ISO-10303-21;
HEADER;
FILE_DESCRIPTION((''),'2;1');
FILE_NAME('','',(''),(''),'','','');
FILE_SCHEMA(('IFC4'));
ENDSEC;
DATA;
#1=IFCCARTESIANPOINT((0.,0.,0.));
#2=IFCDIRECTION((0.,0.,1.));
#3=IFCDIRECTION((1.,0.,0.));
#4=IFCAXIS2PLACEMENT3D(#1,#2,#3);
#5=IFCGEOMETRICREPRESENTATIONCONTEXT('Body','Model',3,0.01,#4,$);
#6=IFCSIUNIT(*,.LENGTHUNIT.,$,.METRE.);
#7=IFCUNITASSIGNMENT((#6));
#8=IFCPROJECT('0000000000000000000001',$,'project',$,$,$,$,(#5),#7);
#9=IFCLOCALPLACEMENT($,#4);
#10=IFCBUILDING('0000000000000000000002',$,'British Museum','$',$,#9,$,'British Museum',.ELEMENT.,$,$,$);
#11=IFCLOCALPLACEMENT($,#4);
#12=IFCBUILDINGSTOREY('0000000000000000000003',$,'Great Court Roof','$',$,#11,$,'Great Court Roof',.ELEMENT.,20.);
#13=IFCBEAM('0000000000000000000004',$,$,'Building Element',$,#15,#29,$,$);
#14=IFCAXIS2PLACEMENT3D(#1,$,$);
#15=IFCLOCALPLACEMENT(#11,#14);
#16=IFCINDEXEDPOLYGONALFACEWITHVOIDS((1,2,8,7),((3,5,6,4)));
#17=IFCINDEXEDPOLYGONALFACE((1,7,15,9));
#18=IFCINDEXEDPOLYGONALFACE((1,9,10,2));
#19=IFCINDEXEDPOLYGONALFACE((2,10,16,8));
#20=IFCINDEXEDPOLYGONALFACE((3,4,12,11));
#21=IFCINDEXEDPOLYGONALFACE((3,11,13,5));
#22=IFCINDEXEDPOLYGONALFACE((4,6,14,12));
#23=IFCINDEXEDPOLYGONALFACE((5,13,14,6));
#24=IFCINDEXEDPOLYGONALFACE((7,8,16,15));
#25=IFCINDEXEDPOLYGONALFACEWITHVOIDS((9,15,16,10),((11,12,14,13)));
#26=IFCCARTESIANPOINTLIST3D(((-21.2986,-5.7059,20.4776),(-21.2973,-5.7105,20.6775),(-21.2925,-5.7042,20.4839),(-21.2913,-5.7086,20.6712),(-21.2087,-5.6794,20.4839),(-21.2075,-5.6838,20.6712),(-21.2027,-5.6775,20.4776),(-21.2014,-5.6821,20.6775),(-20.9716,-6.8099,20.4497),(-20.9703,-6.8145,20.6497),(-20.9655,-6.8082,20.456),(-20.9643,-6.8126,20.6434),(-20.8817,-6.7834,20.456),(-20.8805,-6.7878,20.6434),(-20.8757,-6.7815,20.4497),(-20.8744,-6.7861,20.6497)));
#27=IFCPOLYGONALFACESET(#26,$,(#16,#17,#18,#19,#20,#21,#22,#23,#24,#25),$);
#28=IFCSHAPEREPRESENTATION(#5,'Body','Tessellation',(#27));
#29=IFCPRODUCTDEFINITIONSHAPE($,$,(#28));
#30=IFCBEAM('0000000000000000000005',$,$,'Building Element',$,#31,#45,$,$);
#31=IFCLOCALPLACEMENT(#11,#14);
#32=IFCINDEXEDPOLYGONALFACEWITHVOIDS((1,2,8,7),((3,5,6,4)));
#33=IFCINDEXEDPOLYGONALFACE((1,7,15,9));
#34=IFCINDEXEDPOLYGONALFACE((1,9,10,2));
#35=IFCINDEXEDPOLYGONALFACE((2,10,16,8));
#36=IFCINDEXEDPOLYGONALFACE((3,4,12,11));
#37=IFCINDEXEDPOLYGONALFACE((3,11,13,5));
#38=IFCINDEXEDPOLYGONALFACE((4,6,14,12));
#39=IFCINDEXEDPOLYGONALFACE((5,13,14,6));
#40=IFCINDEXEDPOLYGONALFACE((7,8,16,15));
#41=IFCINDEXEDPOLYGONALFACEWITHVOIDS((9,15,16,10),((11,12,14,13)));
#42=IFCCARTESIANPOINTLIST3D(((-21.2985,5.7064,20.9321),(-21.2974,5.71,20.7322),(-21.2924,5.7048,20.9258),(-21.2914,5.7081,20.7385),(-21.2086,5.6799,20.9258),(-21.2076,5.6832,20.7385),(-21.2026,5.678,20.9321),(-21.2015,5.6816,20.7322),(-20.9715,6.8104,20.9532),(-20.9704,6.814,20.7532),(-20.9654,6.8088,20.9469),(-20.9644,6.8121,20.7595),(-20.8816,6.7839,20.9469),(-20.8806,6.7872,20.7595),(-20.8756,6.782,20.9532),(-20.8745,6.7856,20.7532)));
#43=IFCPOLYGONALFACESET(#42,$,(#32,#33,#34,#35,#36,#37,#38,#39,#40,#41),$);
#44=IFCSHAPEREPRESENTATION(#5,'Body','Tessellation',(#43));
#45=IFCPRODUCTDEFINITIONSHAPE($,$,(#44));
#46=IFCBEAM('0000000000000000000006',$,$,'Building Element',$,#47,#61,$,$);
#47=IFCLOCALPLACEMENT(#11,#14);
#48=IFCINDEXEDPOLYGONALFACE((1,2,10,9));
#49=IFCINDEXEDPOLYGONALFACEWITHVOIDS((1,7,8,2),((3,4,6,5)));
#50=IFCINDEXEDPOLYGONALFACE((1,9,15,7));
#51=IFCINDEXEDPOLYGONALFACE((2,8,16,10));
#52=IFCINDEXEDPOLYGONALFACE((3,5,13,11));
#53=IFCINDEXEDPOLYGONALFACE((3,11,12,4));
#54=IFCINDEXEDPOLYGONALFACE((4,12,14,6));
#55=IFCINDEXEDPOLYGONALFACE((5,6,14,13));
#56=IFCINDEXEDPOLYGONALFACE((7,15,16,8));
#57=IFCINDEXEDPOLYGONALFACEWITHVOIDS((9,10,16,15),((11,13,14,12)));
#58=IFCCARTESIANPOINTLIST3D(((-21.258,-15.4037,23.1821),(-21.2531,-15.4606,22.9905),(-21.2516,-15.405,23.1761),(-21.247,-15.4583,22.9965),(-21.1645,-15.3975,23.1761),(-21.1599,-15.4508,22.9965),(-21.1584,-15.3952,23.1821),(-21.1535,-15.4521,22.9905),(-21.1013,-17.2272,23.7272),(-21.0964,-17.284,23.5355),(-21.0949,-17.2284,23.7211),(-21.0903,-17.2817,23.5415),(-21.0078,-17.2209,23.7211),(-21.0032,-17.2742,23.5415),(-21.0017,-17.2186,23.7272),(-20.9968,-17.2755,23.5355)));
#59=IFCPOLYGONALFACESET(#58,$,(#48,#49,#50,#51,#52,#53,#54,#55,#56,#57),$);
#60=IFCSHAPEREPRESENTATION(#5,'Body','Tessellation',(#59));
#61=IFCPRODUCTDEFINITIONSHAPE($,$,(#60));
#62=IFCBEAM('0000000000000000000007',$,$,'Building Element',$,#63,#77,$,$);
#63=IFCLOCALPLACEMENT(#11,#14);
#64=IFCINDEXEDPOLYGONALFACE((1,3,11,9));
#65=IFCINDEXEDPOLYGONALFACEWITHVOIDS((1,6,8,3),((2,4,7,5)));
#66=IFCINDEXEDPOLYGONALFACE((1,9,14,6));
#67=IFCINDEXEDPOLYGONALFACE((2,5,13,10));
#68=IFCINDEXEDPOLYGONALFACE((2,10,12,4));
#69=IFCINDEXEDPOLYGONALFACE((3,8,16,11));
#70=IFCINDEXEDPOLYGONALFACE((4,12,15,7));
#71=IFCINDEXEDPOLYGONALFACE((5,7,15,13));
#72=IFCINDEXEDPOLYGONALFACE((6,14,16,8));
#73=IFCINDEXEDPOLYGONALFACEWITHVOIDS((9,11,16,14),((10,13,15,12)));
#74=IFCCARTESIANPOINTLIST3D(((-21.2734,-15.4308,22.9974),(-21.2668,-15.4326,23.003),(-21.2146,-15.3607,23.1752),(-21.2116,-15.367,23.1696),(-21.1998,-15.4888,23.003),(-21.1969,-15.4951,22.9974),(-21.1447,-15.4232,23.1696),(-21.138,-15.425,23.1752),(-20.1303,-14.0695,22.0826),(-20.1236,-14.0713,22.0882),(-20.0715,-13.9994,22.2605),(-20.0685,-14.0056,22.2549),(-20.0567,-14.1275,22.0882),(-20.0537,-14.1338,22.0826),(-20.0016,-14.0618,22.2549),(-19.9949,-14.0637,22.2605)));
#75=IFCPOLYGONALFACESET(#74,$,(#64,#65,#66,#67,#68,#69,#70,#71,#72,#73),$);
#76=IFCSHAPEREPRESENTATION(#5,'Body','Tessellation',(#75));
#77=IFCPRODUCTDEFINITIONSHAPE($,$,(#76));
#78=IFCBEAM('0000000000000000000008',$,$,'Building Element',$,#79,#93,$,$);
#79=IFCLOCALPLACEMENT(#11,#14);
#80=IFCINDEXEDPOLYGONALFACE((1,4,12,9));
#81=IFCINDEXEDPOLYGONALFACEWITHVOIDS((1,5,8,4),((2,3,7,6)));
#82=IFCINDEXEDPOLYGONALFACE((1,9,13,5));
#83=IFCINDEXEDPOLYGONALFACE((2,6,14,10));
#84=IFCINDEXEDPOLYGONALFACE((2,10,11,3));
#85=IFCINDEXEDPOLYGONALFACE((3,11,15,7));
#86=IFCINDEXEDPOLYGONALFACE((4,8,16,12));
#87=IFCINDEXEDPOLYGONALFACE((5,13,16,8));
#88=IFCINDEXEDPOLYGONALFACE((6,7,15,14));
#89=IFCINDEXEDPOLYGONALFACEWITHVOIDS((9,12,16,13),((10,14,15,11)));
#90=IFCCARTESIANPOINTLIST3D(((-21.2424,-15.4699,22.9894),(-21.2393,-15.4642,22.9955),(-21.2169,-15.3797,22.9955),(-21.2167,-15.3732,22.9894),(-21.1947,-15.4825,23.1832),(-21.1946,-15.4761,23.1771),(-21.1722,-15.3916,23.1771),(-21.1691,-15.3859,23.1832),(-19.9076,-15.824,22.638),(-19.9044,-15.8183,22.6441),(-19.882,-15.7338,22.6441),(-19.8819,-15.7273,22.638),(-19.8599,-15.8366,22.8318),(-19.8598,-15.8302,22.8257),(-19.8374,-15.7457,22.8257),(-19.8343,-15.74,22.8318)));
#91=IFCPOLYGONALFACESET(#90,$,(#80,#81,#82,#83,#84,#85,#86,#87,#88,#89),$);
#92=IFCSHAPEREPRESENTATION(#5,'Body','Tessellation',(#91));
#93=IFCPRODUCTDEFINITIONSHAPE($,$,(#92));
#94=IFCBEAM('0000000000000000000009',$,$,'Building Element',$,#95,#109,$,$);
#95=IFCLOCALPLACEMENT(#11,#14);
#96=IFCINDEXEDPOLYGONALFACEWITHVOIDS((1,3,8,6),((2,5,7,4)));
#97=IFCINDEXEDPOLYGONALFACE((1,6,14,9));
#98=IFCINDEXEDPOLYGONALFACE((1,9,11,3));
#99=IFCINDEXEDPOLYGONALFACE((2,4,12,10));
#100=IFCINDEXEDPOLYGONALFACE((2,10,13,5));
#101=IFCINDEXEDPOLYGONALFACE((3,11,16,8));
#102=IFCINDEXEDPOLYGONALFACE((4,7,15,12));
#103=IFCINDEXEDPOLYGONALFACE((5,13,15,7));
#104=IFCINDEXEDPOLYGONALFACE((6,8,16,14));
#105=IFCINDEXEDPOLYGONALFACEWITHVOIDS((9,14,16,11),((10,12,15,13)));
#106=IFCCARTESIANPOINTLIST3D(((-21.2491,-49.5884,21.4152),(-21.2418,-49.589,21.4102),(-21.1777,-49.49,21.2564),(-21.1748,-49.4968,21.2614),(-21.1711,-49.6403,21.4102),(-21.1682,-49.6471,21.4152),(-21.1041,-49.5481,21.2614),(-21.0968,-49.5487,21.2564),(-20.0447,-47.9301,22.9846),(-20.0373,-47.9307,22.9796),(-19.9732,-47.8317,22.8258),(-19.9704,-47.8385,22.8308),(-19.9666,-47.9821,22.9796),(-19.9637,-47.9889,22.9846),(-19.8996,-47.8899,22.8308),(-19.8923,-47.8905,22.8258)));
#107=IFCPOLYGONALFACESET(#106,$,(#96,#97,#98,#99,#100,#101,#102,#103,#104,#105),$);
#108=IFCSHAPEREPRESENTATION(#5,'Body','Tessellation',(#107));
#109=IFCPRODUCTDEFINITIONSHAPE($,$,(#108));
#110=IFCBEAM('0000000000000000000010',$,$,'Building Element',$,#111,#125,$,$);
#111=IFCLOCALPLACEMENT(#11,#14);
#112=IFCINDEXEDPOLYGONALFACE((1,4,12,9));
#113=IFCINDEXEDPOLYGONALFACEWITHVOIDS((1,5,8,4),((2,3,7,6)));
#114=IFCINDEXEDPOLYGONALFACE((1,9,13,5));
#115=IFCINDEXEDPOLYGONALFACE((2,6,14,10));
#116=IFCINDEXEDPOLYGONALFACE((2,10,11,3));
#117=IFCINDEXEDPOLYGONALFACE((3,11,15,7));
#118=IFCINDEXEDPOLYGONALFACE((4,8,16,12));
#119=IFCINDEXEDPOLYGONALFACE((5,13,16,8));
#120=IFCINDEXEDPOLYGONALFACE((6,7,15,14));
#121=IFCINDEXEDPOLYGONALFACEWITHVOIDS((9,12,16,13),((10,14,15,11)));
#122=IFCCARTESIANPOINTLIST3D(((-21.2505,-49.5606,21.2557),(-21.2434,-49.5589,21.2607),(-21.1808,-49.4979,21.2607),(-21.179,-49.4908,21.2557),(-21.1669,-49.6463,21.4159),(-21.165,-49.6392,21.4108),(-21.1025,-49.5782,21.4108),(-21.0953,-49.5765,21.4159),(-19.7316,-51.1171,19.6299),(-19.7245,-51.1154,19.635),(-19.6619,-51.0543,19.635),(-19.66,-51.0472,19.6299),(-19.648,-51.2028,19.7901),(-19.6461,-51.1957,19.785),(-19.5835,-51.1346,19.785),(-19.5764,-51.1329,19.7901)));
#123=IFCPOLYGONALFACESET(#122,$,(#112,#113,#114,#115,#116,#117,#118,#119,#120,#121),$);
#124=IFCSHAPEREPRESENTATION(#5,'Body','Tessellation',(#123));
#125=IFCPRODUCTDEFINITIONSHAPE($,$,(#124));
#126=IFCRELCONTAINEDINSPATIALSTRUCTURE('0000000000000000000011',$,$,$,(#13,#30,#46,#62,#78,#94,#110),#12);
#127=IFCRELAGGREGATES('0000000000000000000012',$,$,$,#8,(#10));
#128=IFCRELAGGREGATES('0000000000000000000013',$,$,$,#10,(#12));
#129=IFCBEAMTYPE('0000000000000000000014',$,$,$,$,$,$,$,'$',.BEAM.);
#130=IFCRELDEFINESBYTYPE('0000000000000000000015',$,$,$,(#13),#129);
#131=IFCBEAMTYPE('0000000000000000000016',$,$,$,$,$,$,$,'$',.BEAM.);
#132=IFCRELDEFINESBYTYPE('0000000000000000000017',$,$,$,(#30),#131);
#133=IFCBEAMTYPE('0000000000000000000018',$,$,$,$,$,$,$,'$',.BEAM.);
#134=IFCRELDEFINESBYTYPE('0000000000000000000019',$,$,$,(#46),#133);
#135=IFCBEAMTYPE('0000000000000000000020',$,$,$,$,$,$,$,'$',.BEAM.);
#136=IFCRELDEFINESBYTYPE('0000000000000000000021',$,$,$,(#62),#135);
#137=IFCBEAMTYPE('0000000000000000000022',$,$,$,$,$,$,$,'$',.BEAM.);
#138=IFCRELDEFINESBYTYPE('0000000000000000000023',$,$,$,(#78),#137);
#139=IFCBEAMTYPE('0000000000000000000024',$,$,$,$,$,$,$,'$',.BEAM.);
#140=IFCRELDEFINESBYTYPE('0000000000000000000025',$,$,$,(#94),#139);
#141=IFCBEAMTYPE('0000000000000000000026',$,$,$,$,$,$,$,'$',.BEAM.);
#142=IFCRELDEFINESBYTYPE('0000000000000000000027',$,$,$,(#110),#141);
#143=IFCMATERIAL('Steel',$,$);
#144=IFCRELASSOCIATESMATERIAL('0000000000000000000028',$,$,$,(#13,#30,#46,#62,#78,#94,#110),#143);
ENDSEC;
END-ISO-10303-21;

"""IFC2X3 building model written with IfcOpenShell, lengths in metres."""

from ifc_helpers import new_model, si_unit, frame, origin_with_axes, origin_2d, place, context, project, spatial, hollow_rectangle, extrude, material, type_object, element, save


model = new_model("IFC2X3")

# Units and contexts
model_context = context("Model", 3, precision=0.01, world=origin_with_axes(), identifier="Body")
ifc_project = project(units=[si_unit("LENGTHUNIT", "METRE")], contexts=[model_context])

# Building, storey
building_placement = place(None, origin_with_axes())
building = spatial("IfcBuilding", under=ifc_project, at=building_placement, Name="British Museum", Description="$", LongName="British Museum", CompositionType="ELEMENT")
storey_placement = place(None, origin_with_axes())
storey = spatial("IfcBuildingStorey", under=building, at=storey_placement, Name="Great Court Roof", Description="$", LongName="Great Court Roof", CompositionType="ELEMENT", Elevation=20.0)

# Beams
ifc_material = material(Name="Steel")
beam_type_1 = type_object("IfcBeamType", ElementType="$", PredefinedType="BEAM")
beam_1_placement = place(None, origin_with_axes())
element("IfcBeam", 1, at=beam_1_placement, inside=storey, type_object=beam_type_1, material=ifc_material, Description="Building Element", context=model_context, shape_type="SweptSolid", body=[
    extrude(hollow_rectangle(XDim=0.1, YDim=0.2, WallThickness=0.0063, InnerFilletRadius=-0.0063, OuterFilletRadius=0.0, at=origin_2d()), frame((-21.25, -5.694, 20.5775), z_axis=(0.283917, -0.958544, -0.024167), x_axis=(0.958824, 0.284, 0.0)), (0.0, 0.0, 1.0), 1.1517),
])
beam_type_2 = type_object("IfcBeamType", ElementType="$", PredefinedType="BEAM")
beam_2_placement = place(None, origin_with_axes())
element("IfcBeam", 2, at=beam_2_placement, inside=storey, type_object=beam_type_2, material=ifc_material, Description="Building Element", context=model_context, shape_type="SweptSolid", body=[
    extrude(hollow_rectangle(XDim=0.1, YDim=0.2, WallThickness=0.0063, InnerFilletRadius=-0.0063, OuterFilletRadius=0.0, at=origin_2d()), frame((-21.25, 5.694, 20.8322), z_axis=(0.283952, 0.958664, 0.018263), x_axis=(-0.958824, 0.284, 0.0)), (0.0, 0.0, 1.0), 1.1516),
])
beam_type_3 = type_object("IfcBeamType", ElementType="$", PredefinedType="BEAM")
beam_3_placement = place(None, origin_with_axes())
element("IfcBeam", 3, at=beam_3_placement, inside=storey, type_object=beam_type_3, material=ifc_material, Description="Building Element", context=model_context, shape_type="SweptSolid", body=[
    extrude(hollow_rectangle(XDim=0.1, YDim=0.2, WallThickness=0.0063, InnerFilletRadius=-0.0063, OuterFilletRadius=0.0, at=origin_2d()), frame((-21.2057, -15.4279, 23.0863), z_axis=(0.082065, -0.954885, 0.285411), x_axis=(0.996327, 0.085626, 0.0)), (0.0, 0.0, 1.0), 1.9096),
])
beam_type_4 = type_object("IfcBeamType", ElementType="$", PredefinedType="BEAM")
beam_4_placement = place(None, origin_with_axes())
element("IfcBeam", 4, at=beam_4_placement, inside=storey, type_object=beam_type_4, material=ifc_material, Description="Building Element", context=model_context, shape_type="SweptSolid", body=[
    extrude(hollow_rectangle(XDim=0.1, YDim=0.2, WallThickness=0.0063, InnerFilletRadius=-0.0063, OuterFilletRadius=0.0, at=origin_2d()), frame((-21.2057, -15.4279, 23.0863), z_axis=(0.571802, 0.680936, -0.457568), x_axis=(-0.765807, 0.643071, 0.0)), (0.0, 0.0, 1.0), 1.9992),
])
beam_type_5 = type_object("IfcBeamType", ElementType="$", PredefinedType="BEAM")
beam_5_placement = place(None, origin_with_axes())
element("IfcBeam", 5, at=beam_5_placement, inside=storey, type_object=beam_type_5, material=ifc_material, Description="Building Element", context=model_context, shape_type="SweptSolid", body=[
    extrude(hollow_rectangle(XDim=0.1, YDim=0.2, WallThickness=0.0063, InnerFilletRadius=-0.0063, OuterFilletRadius=0.0, at=origin_2d()), frame((-21.2057, -15.4279, 23.0863), z_axis=(0.936723, -0.248487, -0.246586), x_axis=(0.256405, 0.966569, 0.0)), (0.0, 0.0, 1.0), 1.425),
])
beam_type_6 = type_object("IfcBeamType", ElementType="$", PredefinedType="BEAM")
beam_6_placement = place(None, origin_with_axes())
element("IfcBeam", 6, at=beam_6_placement, inside=storey, type_object=beam_type_6, material=ifc_material, Description="Building Element", context=model_context, shape_type="SweptSolid", body=[
    extrude(hollow_rectangle(XDim=0.1, YDim=0.2, WallThickness=0.0063, InnerFilletRadius=-0.0063, OuterFilletRadius=0.0, at=origin_2d()), frame((-21.1729, -49.5685, 21.3358), z_axis=(0.466592, 0.642388, 0.607972), x_axis=(-0.809095, 0.587677, 0.0)), (0.0, 0.0, 1.0), 2.5814),
])
beam_type_7 = type_object("IfcBeamType", ElementType="$", PredefinedType="BEAM")
beam_7_placement = place(None, origin_with_axes())
element("IfcBeam", 7, at=beam_7_placement, inside=storey, type_object=beam_type_7, material=ifc_material, Description="Building Element", context=model_context, shape_type="SweptSolid", body=[
    extrude(hollow_rectangle(XDim=0.1, YDim=0.2, WallThickness=0.0063, InnerFilletRadius=-0.0063, OuterFilletRadius=0.0, at=origin_2d()), frame((-21.1729, -49.5685, 21.3358), z_axis=(0.5594, -0.573218, -0.598743), x_axis=(0.71568, 0.698428, 0.0)), (0.0, 0.0, 1.0), 2.7153),
])

save(model, "model.ifc")
